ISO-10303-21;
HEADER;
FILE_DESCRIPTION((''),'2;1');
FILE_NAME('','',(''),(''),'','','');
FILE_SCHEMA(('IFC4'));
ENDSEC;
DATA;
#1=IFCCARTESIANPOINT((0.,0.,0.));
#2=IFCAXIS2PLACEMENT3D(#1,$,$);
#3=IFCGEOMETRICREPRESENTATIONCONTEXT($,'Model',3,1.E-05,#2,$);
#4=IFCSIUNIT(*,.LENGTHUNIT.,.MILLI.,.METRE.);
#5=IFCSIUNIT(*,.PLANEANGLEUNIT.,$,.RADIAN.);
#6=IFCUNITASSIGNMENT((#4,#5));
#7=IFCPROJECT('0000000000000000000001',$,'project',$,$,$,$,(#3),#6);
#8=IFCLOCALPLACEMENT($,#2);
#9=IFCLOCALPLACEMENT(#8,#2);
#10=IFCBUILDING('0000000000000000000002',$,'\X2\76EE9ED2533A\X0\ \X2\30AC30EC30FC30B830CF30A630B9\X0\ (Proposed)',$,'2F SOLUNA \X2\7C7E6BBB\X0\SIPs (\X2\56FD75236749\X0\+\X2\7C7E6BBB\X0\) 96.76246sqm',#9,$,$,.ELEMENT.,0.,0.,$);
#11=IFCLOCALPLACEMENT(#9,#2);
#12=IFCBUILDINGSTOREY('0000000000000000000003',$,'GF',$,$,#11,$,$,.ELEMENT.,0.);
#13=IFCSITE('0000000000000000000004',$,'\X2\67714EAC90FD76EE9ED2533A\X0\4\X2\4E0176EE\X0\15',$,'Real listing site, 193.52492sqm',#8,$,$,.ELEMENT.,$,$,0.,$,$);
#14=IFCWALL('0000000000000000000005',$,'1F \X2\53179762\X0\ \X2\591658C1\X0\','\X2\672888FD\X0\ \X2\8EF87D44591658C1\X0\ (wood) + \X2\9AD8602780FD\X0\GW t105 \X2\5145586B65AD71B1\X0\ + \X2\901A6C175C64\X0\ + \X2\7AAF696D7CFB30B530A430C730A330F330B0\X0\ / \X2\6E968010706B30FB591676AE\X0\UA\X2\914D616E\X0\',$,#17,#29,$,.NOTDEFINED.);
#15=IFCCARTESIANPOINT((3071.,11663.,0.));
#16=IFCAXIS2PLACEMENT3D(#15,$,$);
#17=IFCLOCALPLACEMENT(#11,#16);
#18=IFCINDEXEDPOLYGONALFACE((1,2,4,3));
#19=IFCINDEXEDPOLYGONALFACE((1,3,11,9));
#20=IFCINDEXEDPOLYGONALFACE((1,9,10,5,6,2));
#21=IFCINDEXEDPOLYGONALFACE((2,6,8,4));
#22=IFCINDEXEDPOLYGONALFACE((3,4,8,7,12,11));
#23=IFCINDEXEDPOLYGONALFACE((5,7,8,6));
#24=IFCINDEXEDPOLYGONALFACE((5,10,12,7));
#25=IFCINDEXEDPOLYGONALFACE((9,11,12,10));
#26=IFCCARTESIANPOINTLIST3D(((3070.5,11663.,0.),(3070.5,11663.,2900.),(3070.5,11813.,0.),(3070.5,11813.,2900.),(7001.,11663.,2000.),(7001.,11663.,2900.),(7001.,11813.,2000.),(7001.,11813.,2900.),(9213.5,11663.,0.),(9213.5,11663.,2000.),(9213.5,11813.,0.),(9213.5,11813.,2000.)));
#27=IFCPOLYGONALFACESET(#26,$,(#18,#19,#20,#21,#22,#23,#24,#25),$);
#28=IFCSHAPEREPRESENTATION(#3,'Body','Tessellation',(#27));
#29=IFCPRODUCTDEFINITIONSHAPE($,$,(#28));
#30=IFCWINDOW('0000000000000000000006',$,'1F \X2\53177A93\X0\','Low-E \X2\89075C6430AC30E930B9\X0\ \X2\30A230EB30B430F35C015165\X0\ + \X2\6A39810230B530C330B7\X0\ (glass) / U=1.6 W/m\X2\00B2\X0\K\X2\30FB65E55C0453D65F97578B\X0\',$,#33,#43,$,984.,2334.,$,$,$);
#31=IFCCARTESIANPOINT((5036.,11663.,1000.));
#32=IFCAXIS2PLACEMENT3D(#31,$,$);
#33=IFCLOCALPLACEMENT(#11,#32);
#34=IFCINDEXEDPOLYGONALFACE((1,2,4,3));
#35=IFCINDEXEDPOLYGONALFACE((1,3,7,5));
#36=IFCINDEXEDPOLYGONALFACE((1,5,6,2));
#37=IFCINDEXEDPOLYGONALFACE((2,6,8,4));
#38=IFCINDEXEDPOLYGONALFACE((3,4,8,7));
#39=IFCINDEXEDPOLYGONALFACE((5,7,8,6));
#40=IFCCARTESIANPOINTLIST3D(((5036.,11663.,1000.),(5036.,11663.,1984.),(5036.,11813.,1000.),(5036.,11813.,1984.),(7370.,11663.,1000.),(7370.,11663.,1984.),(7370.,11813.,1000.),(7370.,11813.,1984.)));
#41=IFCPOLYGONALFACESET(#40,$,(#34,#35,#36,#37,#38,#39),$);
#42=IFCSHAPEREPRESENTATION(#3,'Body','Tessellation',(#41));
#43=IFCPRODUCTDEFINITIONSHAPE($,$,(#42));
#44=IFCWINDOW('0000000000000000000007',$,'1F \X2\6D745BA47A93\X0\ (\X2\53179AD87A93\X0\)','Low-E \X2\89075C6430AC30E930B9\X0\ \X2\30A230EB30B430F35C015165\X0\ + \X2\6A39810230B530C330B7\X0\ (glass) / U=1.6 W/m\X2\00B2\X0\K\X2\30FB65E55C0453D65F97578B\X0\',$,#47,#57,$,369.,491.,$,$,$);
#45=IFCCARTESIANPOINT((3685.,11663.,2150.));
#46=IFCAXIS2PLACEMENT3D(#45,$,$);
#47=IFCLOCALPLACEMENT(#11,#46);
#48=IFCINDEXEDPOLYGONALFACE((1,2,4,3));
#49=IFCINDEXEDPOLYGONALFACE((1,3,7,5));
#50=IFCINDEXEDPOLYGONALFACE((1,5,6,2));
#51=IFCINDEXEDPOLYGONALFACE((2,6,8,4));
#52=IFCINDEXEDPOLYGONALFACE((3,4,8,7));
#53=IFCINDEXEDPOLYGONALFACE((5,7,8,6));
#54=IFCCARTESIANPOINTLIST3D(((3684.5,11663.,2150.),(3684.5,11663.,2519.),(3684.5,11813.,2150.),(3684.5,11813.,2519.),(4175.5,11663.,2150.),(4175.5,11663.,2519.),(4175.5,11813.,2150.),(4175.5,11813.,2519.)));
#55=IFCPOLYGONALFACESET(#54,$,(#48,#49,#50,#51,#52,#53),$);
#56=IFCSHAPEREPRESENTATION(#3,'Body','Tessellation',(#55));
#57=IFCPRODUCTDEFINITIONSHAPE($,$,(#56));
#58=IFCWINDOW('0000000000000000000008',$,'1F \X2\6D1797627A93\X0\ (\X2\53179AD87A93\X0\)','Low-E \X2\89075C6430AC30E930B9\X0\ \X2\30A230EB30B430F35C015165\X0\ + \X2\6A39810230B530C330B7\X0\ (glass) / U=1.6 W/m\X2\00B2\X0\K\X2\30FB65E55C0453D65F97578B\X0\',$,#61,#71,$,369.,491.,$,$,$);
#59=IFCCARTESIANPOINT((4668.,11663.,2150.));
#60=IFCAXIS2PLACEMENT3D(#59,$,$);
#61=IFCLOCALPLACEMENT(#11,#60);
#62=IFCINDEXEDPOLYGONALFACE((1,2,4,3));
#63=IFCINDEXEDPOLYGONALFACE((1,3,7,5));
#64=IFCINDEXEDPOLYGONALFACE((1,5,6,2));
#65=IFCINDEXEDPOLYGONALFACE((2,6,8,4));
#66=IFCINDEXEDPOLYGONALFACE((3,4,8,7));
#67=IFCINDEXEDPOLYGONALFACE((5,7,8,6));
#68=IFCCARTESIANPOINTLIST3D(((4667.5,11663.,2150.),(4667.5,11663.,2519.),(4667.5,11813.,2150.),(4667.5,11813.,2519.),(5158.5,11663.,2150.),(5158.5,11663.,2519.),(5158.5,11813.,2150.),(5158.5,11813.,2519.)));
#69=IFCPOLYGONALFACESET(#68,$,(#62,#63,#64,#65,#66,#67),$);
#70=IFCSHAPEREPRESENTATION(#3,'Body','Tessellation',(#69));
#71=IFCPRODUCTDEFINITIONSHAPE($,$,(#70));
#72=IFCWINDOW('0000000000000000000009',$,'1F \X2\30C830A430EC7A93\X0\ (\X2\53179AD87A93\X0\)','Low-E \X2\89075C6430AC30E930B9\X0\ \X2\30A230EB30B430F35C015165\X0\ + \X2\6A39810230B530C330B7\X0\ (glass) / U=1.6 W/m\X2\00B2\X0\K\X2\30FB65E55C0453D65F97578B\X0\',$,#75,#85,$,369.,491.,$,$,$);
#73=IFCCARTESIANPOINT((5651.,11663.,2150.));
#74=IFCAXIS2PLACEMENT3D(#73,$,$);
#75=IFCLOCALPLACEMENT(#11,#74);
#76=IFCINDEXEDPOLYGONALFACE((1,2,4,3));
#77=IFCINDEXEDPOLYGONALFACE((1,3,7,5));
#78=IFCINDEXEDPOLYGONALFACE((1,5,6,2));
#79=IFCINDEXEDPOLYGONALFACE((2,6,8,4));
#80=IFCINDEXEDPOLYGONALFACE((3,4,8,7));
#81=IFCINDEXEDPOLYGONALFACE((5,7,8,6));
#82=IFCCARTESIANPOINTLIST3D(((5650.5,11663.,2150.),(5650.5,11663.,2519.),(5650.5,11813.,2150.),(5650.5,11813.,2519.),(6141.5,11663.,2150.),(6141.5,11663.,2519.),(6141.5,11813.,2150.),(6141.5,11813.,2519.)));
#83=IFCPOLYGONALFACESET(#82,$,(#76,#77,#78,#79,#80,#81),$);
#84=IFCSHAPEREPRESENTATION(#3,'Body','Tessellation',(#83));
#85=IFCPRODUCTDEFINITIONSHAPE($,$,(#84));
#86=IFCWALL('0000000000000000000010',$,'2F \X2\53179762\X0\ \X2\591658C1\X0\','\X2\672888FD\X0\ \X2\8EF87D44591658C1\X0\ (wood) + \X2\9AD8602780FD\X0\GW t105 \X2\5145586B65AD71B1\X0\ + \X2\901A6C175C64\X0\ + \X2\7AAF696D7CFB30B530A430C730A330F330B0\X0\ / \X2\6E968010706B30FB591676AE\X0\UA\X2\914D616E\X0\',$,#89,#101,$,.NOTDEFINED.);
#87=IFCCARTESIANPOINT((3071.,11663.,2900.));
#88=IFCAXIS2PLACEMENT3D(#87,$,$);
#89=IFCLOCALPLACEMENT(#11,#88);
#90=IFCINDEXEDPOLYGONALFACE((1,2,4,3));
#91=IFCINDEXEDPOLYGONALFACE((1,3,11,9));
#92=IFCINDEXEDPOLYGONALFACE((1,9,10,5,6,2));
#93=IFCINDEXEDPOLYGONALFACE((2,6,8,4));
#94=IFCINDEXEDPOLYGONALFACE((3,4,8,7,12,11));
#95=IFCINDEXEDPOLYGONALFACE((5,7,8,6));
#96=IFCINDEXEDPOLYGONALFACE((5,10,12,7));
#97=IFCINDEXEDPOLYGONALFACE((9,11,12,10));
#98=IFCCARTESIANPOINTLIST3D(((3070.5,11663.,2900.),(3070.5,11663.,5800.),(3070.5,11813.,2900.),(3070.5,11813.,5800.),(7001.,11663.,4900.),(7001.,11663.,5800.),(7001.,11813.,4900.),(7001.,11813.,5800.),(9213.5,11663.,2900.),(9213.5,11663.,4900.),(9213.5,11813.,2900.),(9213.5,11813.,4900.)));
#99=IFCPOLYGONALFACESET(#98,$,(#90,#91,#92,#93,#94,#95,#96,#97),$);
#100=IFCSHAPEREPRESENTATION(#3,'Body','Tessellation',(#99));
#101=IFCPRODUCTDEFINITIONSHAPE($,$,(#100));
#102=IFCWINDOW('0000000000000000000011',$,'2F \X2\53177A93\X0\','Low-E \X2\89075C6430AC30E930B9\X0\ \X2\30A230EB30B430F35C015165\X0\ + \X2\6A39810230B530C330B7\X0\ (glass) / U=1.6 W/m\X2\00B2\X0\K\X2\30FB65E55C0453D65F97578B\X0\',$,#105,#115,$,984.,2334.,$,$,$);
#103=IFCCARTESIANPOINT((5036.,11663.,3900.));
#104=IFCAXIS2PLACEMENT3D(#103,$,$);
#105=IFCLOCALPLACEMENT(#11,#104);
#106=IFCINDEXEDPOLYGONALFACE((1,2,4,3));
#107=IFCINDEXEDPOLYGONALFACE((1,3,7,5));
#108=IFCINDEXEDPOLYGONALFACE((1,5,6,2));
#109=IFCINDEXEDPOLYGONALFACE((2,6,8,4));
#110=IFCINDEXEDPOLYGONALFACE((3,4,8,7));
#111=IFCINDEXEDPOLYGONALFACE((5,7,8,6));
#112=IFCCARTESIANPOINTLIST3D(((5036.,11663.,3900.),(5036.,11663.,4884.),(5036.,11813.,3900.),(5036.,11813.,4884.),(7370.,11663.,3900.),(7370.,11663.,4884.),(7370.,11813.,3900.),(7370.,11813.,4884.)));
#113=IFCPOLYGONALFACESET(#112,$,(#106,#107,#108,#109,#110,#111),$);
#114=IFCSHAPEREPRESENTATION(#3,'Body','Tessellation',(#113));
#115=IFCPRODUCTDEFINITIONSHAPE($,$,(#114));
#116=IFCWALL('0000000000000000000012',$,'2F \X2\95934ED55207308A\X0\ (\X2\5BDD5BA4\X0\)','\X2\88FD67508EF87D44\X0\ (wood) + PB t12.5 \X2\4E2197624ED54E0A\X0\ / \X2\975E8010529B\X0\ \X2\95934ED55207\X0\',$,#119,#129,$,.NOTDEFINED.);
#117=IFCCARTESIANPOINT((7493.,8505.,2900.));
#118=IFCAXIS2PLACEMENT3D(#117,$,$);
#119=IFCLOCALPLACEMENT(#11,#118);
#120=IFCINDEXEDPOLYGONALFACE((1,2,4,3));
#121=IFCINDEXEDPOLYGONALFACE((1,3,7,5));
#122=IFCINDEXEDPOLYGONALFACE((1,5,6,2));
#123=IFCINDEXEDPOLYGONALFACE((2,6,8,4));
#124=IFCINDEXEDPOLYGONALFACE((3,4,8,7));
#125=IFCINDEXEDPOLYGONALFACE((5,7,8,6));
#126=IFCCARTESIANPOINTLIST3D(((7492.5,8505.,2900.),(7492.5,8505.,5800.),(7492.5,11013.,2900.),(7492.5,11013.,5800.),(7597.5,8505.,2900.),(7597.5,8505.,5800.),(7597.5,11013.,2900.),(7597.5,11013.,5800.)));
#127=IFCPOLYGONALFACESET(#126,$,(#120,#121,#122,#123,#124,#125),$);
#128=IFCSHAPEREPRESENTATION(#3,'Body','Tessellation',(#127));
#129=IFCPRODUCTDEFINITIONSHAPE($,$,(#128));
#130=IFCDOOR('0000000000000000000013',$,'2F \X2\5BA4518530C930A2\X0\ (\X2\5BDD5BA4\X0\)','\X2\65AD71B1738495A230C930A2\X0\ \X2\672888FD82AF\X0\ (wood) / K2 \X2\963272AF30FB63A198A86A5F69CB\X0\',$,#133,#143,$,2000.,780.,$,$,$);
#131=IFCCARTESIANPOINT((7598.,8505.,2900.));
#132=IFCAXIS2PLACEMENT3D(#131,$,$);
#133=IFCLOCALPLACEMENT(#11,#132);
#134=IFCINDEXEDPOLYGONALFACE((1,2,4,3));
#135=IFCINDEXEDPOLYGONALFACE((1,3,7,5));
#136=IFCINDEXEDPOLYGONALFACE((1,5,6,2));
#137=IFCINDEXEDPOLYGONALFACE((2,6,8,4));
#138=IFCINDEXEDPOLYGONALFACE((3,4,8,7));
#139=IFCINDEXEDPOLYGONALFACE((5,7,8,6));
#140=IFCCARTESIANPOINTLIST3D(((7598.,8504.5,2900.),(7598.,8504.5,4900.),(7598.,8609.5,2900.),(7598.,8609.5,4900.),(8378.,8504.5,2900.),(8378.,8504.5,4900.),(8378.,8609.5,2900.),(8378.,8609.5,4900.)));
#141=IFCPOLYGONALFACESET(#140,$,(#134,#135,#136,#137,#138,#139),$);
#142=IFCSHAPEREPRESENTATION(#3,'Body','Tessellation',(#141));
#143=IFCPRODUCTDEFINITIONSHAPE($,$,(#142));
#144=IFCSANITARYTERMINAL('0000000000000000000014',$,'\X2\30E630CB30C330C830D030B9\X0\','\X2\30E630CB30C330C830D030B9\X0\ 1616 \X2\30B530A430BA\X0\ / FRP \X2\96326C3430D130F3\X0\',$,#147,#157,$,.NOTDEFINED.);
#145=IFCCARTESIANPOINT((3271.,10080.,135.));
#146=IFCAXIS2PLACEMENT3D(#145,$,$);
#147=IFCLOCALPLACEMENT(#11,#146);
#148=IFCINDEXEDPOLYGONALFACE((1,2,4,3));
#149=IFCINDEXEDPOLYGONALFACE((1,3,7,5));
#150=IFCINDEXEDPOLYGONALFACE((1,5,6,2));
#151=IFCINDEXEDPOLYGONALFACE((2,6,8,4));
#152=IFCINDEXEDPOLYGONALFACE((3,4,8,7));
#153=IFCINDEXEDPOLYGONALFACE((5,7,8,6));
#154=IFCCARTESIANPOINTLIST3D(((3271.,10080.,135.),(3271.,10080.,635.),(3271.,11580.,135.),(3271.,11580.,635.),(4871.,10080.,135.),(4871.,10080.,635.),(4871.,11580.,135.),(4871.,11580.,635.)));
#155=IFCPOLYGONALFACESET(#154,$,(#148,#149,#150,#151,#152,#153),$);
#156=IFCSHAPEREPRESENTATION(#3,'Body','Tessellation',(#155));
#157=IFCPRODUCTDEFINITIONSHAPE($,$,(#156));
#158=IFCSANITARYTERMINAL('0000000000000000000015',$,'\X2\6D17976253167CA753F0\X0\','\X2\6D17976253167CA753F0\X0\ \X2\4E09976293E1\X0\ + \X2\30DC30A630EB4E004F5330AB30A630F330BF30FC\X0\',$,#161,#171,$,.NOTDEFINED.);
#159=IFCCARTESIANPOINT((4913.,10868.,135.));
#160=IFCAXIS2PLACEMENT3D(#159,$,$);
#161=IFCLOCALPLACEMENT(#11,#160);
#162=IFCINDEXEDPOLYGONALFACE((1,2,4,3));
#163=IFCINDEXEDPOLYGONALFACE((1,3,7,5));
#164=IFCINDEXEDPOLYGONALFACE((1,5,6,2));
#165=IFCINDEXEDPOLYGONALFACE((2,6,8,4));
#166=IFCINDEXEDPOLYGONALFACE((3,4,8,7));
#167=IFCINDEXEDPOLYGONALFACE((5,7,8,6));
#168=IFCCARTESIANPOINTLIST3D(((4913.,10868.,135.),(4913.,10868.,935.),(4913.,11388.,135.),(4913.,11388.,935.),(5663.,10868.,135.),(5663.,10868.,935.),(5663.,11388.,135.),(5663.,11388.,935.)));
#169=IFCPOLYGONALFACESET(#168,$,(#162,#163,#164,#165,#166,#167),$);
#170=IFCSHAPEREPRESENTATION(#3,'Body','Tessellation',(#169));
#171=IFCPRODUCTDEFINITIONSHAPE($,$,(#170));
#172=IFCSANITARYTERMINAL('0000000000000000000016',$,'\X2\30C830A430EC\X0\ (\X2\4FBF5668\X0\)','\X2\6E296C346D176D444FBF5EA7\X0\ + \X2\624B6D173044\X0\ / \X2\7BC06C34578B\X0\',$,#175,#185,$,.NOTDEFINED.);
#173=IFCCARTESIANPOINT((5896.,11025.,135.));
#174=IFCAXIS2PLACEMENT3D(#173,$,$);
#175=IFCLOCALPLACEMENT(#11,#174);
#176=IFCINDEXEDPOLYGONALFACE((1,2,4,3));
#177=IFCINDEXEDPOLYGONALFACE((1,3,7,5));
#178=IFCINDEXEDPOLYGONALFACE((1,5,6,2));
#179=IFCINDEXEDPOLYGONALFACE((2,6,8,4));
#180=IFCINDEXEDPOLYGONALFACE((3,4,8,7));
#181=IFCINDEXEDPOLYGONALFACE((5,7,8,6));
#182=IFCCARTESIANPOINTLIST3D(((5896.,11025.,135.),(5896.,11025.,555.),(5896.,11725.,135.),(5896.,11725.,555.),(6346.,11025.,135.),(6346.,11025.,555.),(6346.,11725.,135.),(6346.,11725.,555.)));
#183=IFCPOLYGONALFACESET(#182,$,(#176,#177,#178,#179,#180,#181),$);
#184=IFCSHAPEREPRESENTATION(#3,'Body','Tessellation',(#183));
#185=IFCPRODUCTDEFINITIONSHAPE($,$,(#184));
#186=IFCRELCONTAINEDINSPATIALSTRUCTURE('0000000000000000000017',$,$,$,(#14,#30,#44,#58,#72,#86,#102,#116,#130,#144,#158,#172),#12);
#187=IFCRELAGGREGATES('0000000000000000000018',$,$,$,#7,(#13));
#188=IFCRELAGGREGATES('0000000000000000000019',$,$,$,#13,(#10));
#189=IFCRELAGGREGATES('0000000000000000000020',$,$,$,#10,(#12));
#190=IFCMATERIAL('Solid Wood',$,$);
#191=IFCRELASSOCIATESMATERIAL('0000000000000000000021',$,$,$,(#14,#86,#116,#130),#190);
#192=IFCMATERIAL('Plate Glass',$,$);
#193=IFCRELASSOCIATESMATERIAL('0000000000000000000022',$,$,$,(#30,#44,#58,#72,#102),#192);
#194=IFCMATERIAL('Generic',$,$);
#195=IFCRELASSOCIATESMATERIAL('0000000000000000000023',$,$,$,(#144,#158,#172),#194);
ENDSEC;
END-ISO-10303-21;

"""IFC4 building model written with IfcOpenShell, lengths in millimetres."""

from ifc_helpers import new_model, si_unit, frame, frame_2d, origin, place, context, project, spatial, rectangle, extrude, material, element, fill, save


model = new_model("IFC4")

# Units and contexts
model_context = context("Model", 3, precision=1e-05, world=origin())
ifc_project = project(units=[si_unit("LENGTHUNIT", "METRE", prefix="MILLI"), si_unit("PLANEANGLEUNIT", "RADIAN")], contexts=[model_context])

# Site, building, storey
site_placement = place(None, origin())
site = spatial("IfcSite", under=ifc_project, at=site_placement, Name="東京都目黒区4丁目15", ObjectType="Real listing site, 193.52492sqm", CompositionType="ELEMENT", RefElevation=0.0)
building_placement = place(site_placement, origin())
building = spatial("IfcBuilding", under=site, at=building_placement, Name="目黒区 ガレージハウス (Proposed)", ObjectType="2F SOLUNA 籾殻SIPs (国産杉+籾殻) 96.76246sqm", CompositionType="ELEMENT", ElevationOfRefHeight=0.0, ElevationOfTerrain=0.0)
storey_placement = place(building_placement, origin())
storey = spatial("IfcBuildingStorey", under=building, at=storey_placement, Name="GF", CompositionType="ELEMENT", Elevation=0.0)

# Wall, openings, windows
ifc_material_1 = material(Name="Solid Wood")
wall_1_placement = place(storey_placement, frame((3071.0, 11663.0, 0.0)))
wall_1 = element("IfcWall", 1, at=wall_1_placement, inside=storey, material=ifc_material_1, Name="1F 北面 外壁", Description="木製 軸組外壁 (wood) + 高性能GW t105 充填断熱 + 通気層 + 窯業系サイディング / 準耐火・外皮UA配慮", PredefinedType="NOTDEFINED", context=model_context, shape_type="SweptSolid", body=[
    extrude(rectangle(XDim=6143.0, YDim=150.0, at=frame_2d((3071.0, 75.0))), frame((3071.0, 11663.0, 0.0)), (0.0, 0.0, 1.0), 2900.0),
])
opening_1_placement = place(storey_placement, frame((5036.0, 11663.0, 1000.0)))
opening_1 = element("IfcOpeningElement", 2, at=opening_1_placement, cuts=wall_1, PredefinedType="NOTDEFINED", context=model_context, shape_type="SweptSolid", body=[
    extrude(rectangle(XDim=2334.0, YDim=150.0, at=frame_2d((1167.0, 75.0))), frame((5036.0, 11663.0, 1000.0)), (0.0, 0.0, 1.0), 984.0),
])
opening_2_placement = place(storey_placement, frame((3685.0, 11663.0, 2150.0)))
opening_2 = element("IfcOpeningElement", 3, at=opening_2_placement, cuts=wall_1, PredefinedType="NOTDEFINED", context=model_context, shape_type="SweptSolid", body=[
    extrude(rectangle(XDim=491.0, YDim=150.0, at=frame_2d((245.0, 75.0))), frame((3685.0, 11663.0, 2150.0)), (0.0, 0.0, 1.0), 369.0),
])
opening_3_placement = place(storey_placement, frame((4668.0, 11663.0, 2150.0)))
opening_3 = element("IfcOpeningElement", 4, at=opening_3_placement, cuts=wall_1, PredefinedType="NOTDEFINED", context=model_context, shape_type="SweptSolid", body=[
    extrude(rectangle(XDim=491.0, YDim=150.0, at=frame_2d((245.0, 75.0))), frame((4668.0, 11663.0, 2150.0)), (0.0, 0.0, 1.0), 369.0),
])
opening_4_placement = place(storey_placement, frame((5651.0, 11663.0, 2150.0)))
opening_4 = element("IfcOpeningElement", 5, at=opening_4_placement, cuts=wall_1, PredefinedType="NOTDEFINED", context=model_context, shape_type="SweptSolid", body=[
    extrude(rectangle(XDim=491.0, YDim=150.0, at=frame_2d((245.0, 75.0))), frame((5651.0, 11663.0, 2150.0)), (0.0, 0.0, 1.0), 369.0),
])
ifc_material_2 = material(Name="Plate Glass")
window_1_placement = place(storey_placement, frame((5036.0, 11663.0, 1000.0)))
window_1 = element("IfcWindow", 6, at=window_1_placement, inside=storey, material=ifc_material_2, Name="1F 北窓", Description="Low-E 複層ガラス アルゴン封入 + 樹脂サッシ (glass) / U=1.6 W/m²K・日射取得型", OverallHeight=984.0, OverallWidth=2334.0, context=model_context, shape_type="SweptSolid", body=[
    extrude(rectangle(XDim=2334.0, YDim=150.0, at=frame_2d((1167.0, 75.0))), frame((5036.0, 11663.0, 1000.0)), (0.0, 0.0, 1.0), 984.0),
])
fill(opening_1, window_1)
window_2_placement = place(storey_placement, frame((3685.0, 11663.0, 2150.0)))
window_2 = element("IfcWindow", 7, at=window_2_placement, inside=storey, material=ifc_material_2, Name="1F 浴室窓 (北高窓)", Description="Low-E 複層ガラス アルゴン封入 + 樹脂サッシ (glass) / U=1.6 W/m²K・日射取得型", OverallHeight=369.0, OverallWidth=491.0, context=model_context, shape_type="SweptSolid", body=[
    extrude(rectangle(XDim=491.0, YDim=150.0, at=frame_2d((245.0, 75.0))), frame((3685.0, 11663.0, 2150.0)), (0.0, 0.0, 1.0), 369.0),
])
fill(opening_2, window_2)
window_3_placement = place(storey_placement, frame((4668.0, 11663.0, 2150.0)))
window_3 = element("IfcWindow", 8, at=window_3_placement, inside=storey, material=ifc_material_2, Name="1F 洗面窓 (北高窓)", Description="Low-E 複層ガラス アルゴン封入 + 樹脂サッシ (glass) / U=1.6 W/m²K・日射取得型", OverallHeight=369.0, OverallWidth=491.0, context=model_context, shape_type="SweptSolid", body=[
    extrude(rectangle(XDim=491.0, YDim=150.0, at=frame_2d((245.0, 75.0))), frame((4668.0, 11663.0, 2150.0)), (0.0, 0.0, 1.0), 369.0),
])
fill(opening_3, window_3)
window_4_placement = place(storey_placement, frame((5651.0, 11663.0, 2150.0)))
window_4 = element("IfcWindow", 9, at=window_4_placement, inside=storey, material=ifc_material_2, Name="1F トイレ窓 (北高窓)", Description="Low-E 複層ガラス アルゴン封入 + 樹脂サッシ (glass) / U=1.6 W/m²K・日射取得型", OverallHeight=369.0, OverallWidth=491.0, context=model_context, shape_type="SweptSolid", body=[
    extrude(rectangle(XDim=491.0, YDim=150.0, at=frame_2d((245.0, 75.0))), frame((5651.0, 11663.0, 2150.0)), (0.0, 0.0, 1.0), 369.0),
])
fill(opening_4, window_4)

# Wall, opening, window
wall_2_placement = place(storey_placement, frame((3071.0, 11663.0, 2900.0)))
wall_2 = element("IfcWall", 10, at=wall_2_placement, inside=storey, material=ifc_material_1, Name="2F 北面 外壁", Description="木製 軸組外壁 (wood) + 高性能GW t105 充填断熱 + 通気層 + 窯業系サイディング / 準耐火・外皮UA配慮", PredefinedType="NOTDEFINED", context=model_context, shape_type="SweptSolid", body=[
    extrude(rectangle(XDim=6143.0, YDim=150.0, at=frame_2d((3071.0, 75.0))), frame((3071.0, 11663.0, 2900.0)), (0.0, 0.0, 1.0), 2900.0),
])
opening_5_placement = place(storey_placement, frame((5036.0, 11663.0, 3900.0)))
opening_5 = element("IfcOpeningElement", 11, at=opening_5_placement, cuts=wall_2, PredefinedType="NOTDEFINED", context=model_context, shape_type="SweptSolid", body=[
    extrude(rectangle(XDim=2334.0, YDim=150.0, at=frame_2d((1167.0, 75.0))), frame((5036.0, 11663.0, 3900.0)), (0.0, 0.0, 1.0), 984.0),
])
window_5_placement = place(storey_placement, frame((5036.0, 11663.0, 3900.0)))
window_5 = element("IfcWindow", 12, at=window_5_placement, inside=storey, material=ifc_material_2, Name="2F 北窓", Description="Low-E 複層ガラス アルゴン封入 + 樹脂サッシ (glass) / U=1.6 W/m²K・日射取得型", OverallHeight=984.0, OverallWidth=2334.0, context=model_context, shape_type="SweptSolid", body=[
    extrude(rectangle(XDim=2334.0, YDim=150.0, at=frame_2d((1167.0, 75.0))), frame((5036.0, 11663.0, 3900.0)), (0.0, 0.0, 1.0), 984.0),
])
fill(opening_5, window_5)

# Wall
wall_3_placement = place(storey_placement, frame((7493.0, 8505.0, 2900.0)))
element("IfcWall", 13, at=wall_3_placement, inside=storey, material=ifc_material_1, Name="2F 間仕切り (寝室)", Description="製材軸組 (wood) + PB t12.5 両面仕上 / 非耐力 間仕切", PredefinedType="NOTDEFINED", context=model_context, shape_type="SweptSolid", body=[
    extrude(rectangle(XDim=105.0, YDim=2508.0, at=frame_2d((52.0, 1254.0))), frame((7493.0, 8505.0, 2900.0)), (0.0, 0.0, 1.0), 2900.0),
])

# Door
door_1_placement = place(storey_placement, frame((7598.0, 8505.0, 2900.0)))
element("IfcDoor", 14, at=door_1_placement, inside=storey, material=ifc_material_1, Name="2F 室内ドア (寝室)", Description="断熱玄関ドア 木製芯 (wood) / K2 防犯・採風機構", OverallHeight=2000.0, OverallWidth=780.0, context=model_context, shape_type="SweptSolid", body=[
    extrude(rectangle(XDim=780.0, YDim=105.0, at=frame_2d((390.0, 52.0))), frame((7598.0, 8505.0, 2900.0)), (0.0, 0.0, 1.0), 2000.0),
])

# Sanitary terminals
ifc_material_3 = material(Name="Generic")
sanitary_terminal_1_placement = place(storey_placement, frame((3271.0, 10080.0, 135.0)))
element("IfcSanitaryTerminal", 15, at=sanitary_terminal_1_placement, inside=storey, material=ifc_material_3, Name="ユニットバス", Description="ユニットバス 1616 サイズ / FRP 防水パン", PredefinedType="NOTDEFINED", context=model_context, shape_type="SweptSolid", body=[
    extrude(rectangle(XDim=1600.0, YDim=1500.0, at=frame_2d((800.0, 750.0))), frame((3271.0, 10080.0, 135.0)), (0.0, 0.0, 1.0), 500.0),
])
sanitary_terminal_2_placement = place(storey_placement, frame((4913.0, 10868.0, 135.0)))
element("IfcSanitaryTerminal", 16, at=sanitary_terminal_2_placement, inside=storey, material=ifc_material_3, Name="洗面化粧台", Description="洗面化粧台 三面鏡 + ボウル一体カウンター", PredefinedType="NOTDEFINED", context=model_context, shape_type="SweptSolid", body=[
    extrude(rectangle(XDim=750.0, YDim=520.0, at=frame_2d((375.0, 260.0))), frame((4913.0, 10868.0, 135.0)), (0.0, 0.0, 1.0), 800.0),
])
sanitary_terminal_3_placement = place(storey_placement, frame((5896.0, 11025.0, 135.0)))
element("IfcSanitaryTerminal", 17, at=sanitary_terminal_3_placement, inside=storey, material=ifc_material_3, Name="トイレ (便器)", Description="温水洗浄便座 + 手洗い / 節水型", PredefinedType="NOTDEFINED", context=model_context, shape_type="SweptSolid", body=[
    extrude(rectangle(XDim=450.0, YDim=700.0, at=frame_2d((225.0, 350.0))), frame((5896.0, 11025.0, 135.0)), (0.0, 0.0, 1.0), 420.0),
])

save(model, "model.ifc")
